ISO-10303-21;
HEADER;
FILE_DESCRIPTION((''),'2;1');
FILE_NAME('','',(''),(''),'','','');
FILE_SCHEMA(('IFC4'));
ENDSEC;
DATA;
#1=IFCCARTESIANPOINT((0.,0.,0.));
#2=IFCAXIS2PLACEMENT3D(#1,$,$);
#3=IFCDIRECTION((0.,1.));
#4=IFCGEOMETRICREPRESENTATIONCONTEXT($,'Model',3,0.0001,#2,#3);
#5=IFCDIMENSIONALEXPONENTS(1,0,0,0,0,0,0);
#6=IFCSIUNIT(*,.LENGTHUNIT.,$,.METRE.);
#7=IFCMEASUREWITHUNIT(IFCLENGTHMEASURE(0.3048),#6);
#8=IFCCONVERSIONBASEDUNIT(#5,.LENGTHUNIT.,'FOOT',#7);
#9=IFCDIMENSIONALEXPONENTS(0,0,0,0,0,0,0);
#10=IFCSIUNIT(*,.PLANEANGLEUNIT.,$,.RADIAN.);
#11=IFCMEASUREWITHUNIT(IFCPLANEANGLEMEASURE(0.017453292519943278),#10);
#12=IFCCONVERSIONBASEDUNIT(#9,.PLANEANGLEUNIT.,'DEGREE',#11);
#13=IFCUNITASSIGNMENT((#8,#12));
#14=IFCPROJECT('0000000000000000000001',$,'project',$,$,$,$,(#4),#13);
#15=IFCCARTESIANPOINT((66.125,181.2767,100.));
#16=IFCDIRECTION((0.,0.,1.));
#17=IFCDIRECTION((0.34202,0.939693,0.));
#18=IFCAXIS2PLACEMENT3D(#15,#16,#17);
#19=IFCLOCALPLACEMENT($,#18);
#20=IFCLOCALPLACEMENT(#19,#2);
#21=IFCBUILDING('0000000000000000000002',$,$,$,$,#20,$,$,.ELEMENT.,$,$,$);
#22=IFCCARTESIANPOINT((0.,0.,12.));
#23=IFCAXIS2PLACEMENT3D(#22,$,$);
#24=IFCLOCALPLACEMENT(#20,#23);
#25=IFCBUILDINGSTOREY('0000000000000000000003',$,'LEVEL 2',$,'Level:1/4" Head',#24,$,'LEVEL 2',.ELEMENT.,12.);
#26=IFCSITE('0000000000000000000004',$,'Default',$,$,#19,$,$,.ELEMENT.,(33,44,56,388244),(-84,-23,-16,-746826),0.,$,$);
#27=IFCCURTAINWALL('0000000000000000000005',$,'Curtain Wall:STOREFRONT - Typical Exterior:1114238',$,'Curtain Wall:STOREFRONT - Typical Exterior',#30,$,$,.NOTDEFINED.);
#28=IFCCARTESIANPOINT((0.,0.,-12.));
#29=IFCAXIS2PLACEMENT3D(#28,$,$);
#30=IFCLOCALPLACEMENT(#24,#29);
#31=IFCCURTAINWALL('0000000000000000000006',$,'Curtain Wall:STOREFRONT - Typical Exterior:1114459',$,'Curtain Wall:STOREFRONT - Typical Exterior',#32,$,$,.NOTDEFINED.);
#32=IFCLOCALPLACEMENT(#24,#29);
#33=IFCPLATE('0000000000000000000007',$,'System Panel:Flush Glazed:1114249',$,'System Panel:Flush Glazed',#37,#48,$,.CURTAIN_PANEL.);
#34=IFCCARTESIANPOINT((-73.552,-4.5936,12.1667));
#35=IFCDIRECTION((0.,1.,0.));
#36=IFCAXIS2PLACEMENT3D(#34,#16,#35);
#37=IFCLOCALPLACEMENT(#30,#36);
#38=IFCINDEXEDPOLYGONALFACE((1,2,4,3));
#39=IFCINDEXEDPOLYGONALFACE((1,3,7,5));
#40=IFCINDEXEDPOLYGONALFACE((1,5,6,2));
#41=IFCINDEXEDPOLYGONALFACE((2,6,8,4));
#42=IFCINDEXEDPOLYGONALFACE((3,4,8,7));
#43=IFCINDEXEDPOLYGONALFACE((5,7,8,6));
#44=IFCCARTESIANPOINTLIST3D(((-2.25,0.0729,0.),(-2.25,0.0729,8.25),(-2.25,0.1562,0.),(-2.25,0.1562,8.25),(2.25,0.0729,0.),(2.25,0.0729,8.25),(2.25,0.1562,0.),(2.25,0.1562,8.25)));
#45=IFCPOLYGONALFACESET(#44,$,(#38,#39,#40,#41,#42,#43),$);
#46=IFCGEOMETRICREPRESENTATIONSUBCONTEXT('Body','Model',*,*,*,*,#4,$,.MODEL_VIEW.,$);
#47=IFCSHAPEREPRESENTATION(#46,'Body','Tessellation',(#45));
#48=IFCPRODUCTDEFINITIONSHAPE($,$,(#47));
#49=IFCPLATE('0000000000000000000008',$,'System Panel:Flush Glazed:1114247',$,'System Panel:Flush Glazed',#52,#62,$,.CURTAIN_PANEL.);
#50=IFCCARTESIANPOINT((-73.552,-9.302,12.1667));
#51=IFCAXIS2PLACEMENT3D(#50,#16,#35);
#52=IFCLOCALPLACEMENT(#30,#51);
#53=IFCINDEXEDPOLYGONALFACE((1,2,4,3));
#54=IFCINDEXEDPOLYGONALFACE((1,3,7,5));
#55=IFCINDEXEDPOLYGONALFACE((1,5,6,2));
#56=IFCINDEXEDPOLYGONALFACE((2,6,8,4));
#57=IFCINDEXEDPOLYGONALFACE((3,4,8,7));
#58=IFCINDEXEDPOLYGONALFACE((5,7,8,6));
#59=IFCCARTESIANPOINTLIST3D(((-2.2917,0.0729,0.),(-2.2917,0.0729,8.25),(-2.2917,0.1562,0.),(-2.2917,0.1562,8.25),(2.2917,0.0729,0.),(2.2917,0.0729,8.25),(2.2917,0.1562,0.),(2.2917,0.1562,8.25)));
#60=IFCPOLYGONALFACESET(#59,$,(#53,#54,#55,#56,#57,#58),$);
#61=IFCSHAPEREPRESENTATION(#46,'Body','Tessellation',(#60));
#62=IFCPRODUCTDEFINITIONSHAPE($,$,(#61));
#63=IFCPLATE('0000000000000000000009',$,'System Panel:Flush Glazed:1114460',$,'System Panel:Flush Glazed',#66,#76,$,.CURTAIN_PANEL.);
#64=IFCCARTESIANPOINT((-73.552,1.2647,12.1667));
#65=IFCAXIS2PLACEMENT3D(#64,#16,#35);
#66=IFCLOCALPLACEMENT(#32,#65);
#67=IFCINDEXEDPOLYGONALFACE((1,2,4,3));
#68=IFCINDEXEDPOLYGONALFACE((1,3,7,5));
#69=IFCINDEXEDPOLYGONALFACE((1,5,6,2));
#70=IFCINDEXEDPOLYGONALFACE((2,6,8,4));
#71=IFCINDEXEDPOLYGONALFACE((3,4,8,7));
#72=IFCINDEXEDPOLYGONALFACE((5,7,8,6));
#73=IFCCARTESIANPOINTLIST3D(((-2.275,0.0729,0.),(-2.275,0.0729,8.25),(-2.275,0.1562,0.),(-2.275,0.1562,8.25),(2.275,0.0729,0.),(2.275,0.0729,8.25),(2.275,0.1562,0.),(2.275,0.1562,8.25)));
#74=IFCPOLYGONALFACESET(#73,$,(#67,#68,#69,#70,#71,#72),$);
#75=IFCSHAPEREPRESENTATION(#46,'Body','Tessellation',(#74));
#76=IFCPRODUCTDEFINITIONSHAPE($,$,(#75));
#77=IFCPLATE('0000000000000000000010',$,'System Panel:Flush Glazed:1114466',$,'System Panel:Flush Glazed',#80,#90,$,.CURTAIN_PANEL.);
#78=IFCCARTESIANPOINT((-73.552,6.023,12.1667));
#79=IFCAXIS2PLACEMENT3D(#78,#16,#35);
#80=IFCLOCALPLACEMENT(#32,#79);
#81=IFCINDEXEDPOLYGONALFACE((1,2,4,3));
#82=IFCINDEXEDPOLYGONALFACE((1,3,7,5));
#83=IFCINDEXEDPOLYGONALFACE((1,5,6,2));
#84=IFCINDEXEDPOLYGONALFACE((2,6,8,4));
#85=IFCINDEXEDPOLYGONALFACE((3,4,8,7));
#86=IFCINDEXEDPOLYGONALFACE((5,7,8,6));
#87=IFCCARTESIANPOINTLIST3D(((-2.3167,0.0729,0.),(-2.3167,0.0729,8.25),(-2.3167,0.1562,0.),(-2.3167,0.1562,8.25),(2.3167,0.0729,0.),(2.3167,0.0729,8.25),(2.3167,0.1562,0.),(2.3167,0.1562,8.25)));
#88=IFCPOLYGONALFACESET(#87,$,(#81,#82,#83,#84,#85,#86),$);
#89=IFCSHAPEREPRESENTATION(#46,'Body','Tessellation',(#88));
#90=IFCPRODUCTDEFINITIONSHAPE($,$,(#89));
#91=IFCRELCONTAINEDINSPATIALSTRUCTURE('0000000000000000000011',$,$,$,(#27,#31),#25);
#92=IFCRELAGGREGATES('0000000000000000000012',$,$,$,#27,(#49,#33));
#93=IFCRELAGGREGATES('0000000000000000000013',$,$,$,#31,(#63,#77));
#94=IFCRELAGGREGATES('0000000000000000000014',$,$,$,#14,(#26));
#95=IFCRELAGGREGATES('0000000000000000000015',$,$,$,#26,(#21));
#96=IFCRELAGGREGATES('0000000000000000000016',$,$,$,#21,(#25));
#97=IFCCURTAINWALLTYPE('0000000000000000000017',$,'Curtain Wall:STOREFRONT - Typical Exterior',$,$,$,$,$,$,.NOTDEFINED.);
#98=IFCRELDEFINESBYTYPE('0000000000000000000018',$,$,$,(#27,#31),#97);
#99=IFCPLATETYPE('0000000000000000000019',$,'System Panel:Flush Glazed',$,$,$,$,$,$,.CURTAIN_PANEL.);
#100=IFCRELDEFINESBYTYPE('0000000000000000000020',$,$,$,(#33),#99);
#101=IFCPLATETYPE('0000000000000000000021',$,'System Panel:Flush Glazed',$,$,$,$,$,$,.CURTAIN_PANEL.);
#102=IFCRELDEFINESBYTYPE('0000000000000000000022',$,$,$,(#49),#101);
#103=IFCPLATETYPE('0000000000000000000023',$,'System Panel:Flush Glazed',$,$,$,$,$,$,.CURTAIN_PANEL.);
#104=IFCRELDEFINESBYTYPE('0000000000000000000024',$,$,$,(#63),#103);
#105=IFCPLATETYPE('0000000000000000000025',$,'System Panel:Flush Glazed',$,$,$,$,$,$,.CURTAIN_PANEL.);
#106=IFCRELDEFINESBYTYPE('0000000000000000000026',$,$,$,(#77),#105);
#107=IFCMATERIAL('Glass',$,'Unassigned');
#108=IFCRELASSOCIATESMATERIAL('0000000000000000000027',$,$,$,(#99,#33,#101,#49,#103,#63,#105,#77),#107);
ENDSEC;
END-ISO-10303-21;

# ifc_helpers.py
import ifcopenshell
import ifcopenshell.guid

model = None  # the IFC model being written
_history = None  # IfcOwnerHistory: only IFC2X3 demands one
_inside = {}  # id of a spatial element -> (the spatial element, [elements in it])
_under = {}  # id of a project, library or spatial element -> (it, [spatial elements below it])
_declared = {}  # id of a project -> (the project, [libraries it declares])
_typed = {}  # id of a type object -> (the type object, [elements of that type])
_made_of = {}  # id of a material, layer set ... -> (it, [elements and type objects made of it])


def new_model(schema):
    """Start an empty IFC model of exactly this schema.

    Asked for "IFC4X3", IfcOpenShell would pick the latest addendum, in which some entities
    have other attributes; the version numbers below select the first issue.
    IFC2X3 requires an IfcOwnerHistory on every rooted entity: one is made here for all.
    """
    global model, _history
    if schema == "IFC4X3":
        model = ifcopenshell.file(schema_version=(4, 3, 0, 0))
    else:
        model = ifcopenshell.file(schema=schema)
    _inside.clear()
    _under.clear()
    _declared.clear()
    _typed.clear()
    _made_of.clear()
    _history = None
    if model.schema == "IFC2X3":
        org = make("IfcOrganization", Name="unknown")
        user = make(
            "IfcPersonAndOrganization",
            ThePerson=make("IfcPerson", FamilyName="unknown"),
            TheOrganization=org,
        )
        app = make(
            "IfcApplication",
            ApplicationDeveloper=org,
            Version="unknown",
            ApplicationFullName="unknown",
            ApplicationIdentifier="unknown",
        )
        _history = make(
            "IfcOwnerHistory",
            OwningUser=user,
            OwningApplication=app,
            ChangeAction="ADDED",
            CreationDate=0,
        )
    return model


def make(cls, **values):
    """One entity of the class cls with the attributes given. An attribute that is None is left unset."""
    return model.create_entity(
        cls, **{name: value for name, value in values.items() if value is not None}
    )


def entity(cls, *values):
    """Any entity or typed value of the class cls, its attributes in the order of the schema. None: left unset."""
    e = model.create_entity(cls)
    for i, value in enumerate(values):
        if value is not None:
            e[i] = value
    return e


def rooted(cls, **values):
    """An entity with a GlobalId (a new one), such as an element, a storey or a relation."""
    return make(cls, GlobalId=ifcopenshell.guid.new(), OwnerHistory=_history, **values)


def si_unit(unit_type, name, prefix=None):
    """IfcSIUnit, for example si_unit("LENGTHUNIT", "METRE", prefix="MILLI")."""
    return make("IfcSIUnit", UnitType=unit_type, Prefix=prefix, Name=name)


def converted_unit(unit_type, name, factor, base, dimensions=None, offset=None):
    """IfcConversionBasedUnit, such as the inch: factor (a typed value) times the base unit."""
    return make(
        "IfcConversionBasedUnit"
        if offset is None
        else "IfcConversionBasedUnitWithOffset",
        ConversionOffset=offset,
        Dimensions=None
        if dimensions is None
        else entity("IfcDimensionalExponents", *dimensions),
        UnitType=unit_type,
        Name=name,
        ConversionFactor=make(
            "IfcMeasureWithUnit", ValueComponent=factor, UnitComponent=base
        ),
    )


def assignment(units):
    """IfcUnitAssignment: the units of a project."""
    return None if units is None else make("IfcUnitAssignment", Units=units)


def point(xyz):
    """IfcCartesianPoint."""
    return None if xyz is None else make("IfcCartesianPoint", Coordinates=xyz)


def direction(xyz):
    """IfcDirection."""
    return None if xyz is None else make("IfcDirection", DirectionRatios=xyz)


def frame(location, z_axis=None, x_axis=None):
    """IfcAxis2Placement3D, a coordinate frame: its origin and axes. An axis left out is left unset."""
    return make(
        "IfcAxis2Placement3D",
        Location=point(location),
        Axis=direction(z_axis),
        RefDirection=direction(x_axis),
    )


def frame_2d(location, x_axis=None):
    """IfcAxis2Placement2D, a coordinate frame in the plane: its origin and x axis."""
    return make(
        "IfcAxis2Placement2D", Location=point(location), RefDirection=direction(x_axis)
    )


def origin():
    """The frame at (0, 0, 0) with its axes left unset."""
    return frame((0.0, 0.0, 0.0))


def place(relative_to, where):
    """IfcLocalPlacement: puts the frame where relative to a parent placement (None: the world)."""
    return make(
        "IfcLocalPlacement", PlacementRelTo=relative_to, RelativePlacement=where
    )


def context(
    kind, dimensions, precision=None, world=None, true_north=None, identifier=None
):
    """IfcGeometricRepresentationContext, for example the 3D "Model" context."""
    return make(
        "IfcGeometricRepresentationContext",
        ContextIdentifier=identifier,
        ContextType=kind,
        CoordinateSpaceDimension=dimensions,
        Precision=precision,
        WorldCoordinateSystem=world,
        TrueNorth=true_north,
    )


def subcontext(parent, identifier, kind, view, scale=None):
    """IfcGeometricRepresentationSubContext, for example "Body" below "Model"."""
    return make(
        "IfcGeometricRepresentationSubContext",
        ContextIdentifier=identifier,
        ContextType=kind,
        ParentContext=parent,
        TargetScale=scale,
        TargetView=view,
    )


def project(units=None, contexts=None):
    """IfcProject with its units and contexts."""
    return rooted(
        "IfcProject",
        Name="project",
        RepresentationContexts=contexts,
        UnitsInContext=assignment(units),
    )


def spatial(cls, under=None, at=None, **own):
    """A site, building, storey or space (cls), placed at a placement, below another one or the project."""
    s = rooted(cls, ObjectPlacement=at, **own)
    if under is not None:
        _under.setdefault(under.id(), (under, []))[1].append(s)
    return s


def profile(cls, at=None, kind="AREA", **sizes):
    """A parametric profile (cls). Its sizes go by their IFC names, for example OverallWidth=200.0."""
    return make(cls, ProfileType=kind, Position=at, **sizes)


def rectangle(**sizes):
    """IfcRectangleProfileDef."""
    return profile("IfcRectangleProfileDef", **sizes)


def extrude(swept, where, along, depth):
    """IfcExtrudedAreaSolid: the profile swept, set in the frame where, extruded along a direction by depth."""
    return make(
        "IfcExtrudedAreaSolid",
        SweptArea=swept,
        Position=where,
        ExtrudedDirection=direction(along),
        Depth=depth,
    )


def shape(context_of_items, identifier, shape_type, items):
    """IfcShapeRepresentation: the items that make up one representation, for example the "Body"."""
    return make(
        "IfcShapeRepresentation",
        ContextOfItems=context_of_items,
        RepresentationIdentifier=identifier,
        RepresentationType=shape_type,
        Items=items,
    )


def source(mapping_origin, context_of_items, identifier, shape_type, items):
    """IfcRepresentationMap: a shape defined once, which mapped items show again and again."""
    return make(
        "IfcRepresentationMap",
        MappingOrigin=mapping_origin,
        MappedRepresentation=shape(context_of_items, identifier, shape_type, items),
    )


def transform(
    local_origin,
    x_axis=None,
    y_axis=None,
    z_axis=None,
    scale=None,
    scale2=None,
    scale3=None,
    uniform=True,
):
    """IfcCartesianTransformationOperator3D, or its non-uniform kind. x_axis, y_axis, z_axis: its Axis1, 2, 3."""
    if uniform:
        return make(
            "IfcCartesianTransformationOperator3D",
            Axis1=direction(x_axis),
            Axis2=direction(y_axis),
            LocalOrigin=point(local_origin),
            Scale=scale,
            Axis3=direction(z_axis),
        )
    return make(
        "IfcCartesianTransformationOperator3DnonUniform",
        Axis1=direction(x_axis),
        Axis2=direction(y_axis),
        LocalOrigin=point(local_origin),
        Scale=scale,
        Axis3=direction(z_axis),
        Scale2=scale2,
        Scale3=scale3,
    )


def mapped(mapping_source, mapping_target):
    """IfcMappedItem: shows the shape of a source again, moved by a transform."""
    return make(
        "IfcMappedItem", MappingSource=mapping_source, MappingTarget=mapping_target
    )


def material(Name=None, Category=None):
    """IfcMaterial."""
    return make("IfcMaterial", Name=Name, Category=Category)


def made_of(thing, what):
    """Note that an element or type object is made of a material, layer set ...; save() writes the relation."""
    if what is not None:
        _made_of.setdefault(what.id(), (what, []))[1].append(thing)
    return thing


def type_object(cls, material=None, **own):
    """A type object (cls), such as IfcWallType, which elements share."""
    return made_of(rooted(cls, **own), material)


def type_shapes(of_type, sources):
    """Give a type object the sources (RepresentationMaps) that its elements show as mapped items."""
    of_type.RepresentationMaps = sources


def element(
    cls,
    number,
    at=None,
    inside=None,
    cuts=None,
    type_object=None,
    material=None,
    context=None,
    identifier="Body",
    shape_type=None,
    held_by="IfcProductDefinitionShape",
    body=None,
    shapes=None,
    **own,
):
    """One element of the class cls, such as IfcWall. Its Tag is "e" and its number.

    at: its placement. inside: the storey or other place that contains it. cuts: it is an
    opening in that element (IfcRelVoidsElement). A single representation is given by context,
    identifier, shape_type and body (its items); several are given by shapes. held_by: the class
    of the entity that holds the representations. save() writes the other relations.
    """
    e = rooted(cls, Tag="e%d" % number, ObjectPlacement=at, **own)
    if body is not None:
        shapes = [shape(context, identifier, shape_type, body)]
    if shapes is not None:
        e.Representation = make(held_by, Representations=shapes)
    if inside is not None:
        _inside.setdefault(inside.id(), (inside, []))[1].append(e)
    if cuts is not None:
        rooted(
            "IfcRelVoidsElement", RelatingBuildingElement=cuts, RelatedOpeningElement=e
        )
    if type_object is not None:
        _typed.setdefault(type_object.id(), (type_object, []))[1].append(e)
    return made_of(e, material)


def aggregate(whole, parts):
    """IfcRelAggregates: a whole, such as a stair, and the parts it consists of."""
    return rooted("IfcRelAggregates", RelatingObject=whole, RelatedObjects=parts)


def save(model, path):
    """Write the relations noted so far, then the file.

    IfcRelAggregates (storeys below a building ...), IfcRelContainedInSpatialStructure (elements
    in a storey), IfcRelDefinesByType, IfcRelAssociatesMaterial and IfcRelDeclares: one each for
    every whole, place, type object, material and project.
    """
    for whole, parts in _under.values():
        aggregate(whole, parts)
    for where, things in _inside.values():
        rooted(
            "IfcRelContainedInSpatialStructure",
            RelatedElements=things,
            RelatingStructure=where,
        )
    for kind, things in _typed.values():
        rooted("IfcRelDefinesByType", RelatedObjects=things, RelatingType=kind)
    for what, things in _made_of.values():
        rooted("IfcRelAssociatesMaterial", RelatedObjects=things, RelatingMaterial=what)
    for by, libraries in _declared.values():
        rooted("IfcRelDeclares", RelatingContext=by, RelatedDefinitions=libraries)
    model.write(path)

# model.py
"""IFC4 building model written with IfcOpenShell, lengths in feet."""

from ifc_helpers import new_model, entity, si_unit, converted_unit, direction, frame, frame_2d, origin, place, context, subcontext, project, spatial, rectangle, extrude, source, transform, mapped, material, type_object, type_shapes, element, aggregate, save


model = new_model("IFC4")

# Units and contexts
model_context = context("Model", 3, precision=0.0001, world=origin(), true_north=direction((0.0, 1.0)))
body_context = subcontext(model_context, "Body", "Model", "MODEL_VIEW")
ifc_project = project(units=[converted_unit("LENGTHUNIT", "FOOT", entity("IfcLengthMeasure", 0.3048), si_unit("LENGTHUNIT", "METRE"), dimensions=[1, 0, 0, 0, 0, 0, 0]), converted_unit("PLANEANGLEUNIT", "DEGREE", entity("IfcPlaneAngleMeasure", 0.017453292519943278), si_unit("PLANEANGLEUNIT", "RADIAN"), dimensions=[0, 0, 0, 0, 0, 0, 0])], contexts=[model_context])

# Site, building, storey
site_placement = place(None, frame((66.125, 181.2767, 100.0), z_axis=(0.0, 0.0, 1.0), x_axis=(0.34202, 0.939693, 0.0)))
site = spatial("IfcSite", under=ifc_project, at=site_placement, Name="Default", CompositionType="ELEMENT", RefLatitude=(33, 44, 56, 388244), RefLongitude=(-84, -23, -16, -746826), RefElevation=0.0)
building_placement = place(site_placement, origin())
building = spatial("IfcBuilding", under=site, at=building_placement, CompositionType="ELEMENT")
storey_placement = place(building_placement, frame((0.0, 0.0, 12.0)))
storey = spatial("IfcBuildingStorey", under=building, at=storey_placement, Name="LEVEL 2", ObjectType="Level:1/4\" Head", LongName="LEVEL 2", CompositionType="ELEMENT", Elevation=12.0)

# Curtain walls
curtain_wall_type = type_object("IfcCurtainWallType", Name="Curtain Wall:STOREFRONT - Typical Exterior", PredefinedType="NOTDEFINED")
curtain_wall_1_placement = place(storey_placement, frame((0.0, 0.0, -12.0)))
curtain_wall_1 = element("IfcCurtainWall", 1, at=curtain_wall_1_placement, inside=storey, type_object=curtain_wall_type, Name="Curtain Wall:STOREFRONT - Typical Exterior:1114238", ObjectType="Curtain Wall:STOREFRONT - Typical Exterior", PredefinedType="NOTDEFINED")
curtain_wall_2_placement = place(storey_placement, frame((0.0, 0.0, -12.0)))
curtain_wall_2 = element("IfcCurtainWall", 2, at=curtain_wall_2_placement, inside=storey, type_object=curtain_wall_type, Name="Curtain Wall:STOREFRONT - Typical Exterior:1114459", ObjectType="Curtain Wall:STOREFRONT - Typical Exterior", PredefinedType="NOTDEFINED")

# Plates
ifc_material_1 = material(Name="Glass", Category="Unassigned")
plate_type_1 = type_object("IfcPlateType", Name="System Panel:Flush Glazed", PredefinedType="CURTAIN_PANEL", material=ifc_material_1)
shared_shape_1 = source(origin(), body_context, "Body", "SweptSolid", [
    extrude(rectangle(XDim=0.0833, YDim=4.5, at=frame_2d((0.0, 0.0), x_axis=(1.0, 0.0))), frame((0.0, 0.1146, 0.0), z_axis=(0.0, 0.0, 1.0), x_axis=(0.0, 1.0, 0.0)), (0.0, 0.0, 1.0), 8.25),
])
type_shapes(plate_type_1, [shared_shape_1])
plate_1_placement = place(curtain_wall_1_placement, frame((-73.552, -4.5936, 12.1667), z_axis=(0.0, 0.0, 1.0), x_axis=(0.0, 1.0, 0.0)))
plate_1 = element("IfcPlate", 3, at=plate_1_placement, type_object=plate_type_1, material=ifc_material_1, Name="System Panel:Flush Glazed:1114249", ObjectType="System Panel:Flush Glazed", PredefinedType="CURTAIN_PANEL", context=body_context, shape_type="MappedRepresentation", body=[
    mapped(shared_shape_1, transform((0.0, 0.0, 0.0), scale=1.0)),
])
plate_type_2 = type_object("IfcPlateType", Name="System Panel:Flush Glazed", PredefinedType="CURTAIN_PANEL", material=ifc_material_1)
shared_shape_2 = source(origin(), body_context, "Body", "SweptSolid", [
    extrude(rectangle(XDim=0.0833, YDim=4.5833, at=frame_2d((0.0, 0.0), x_axis=(1.0, 0.0))), frame((0.0, 0.1146, 0.0), z_axis=(0.0, 0.0, 1.0), x_axis=(0.0, 1.0, 0.0)), (0.0, 0.0, 1.0), 8.25),
])
type_shapes(plate_type_2, [shared_shape_2])
plate_2_placement = place(curtain_wall_1_placement, frame((-73.552, -9.302, 12.1667), z_axis=(0.0, 0.0, 1.0), x_axis=(0.0, 1.0, 0.0)))
plate_2 = element("IfcPlate", 4, at=plate_2_placement, type_object=plate_type_2, material=ifc_material_1, Name="System Panel:Flush Glazed:1114247", ObjectType="System Panel:Flush Glazed", PredefinedType="CURTAIN_PANEL", context=body_context, shape_type="MappedRepresentation", body=[
    mapped(shared_shape_2, transform((0.0, 0.0, 0.0), scale=1.0)),
])
aggregate(curtain_wall_1, [plate_2, plate_1])
plate_type_3 = type_object("IfcPlateType", Name="System Panel:Flush Glazed", PredefinedType="CURTAIN_PANEL", material=ifc_material_1)
shared_shape_3 = source(origin(), body_context, "Body", "SweptSolid", [
    extrude(rectangle(XDim=0.0833, YDim=4.55, at=frame_2d((0.0, 0.0), x_axis=(1.0, 0.0))), frame((0.0, 0.1146, 0.0), z_axis=(0.0, 0.0, 1.0), x_axis=(0.0, 1.0, 0.0)), (0.0, 0.0, 1.0), 8.25),
])
type_shapes(plate_type_3, [shared_shape_3])
plate_3_placement = place(curtain_wall_2_placement, frame((-73.552, 1.2647, 12.1667), z_axis=(0.0, 0.0, 1.0), x_axis=(0.0, 1.0, 0.0)))
plate_3 = element("IfcPlate", 5, at=plate_3_placement, type_object=plate_type_3, material=ifc_material_1, Name="System Panel:Flush Glazed:1114460", ObjectType="System Panel:Flush Glazed", PredefinedType="CURTAIN_PANEL", context=body_context, shape_type="MappedRepresentation", body=[
    mapped(shared_shape_3, transform((0.0, 0.0, 0.0), scale=1.0)),
])
plate_type_4 = type_object("IfcPlateType", Name="System Panel:Flush Glazed", PredefinedType="CURTAIN_PANEL", material=ifc_material_1)
shared_shape_4 = source(origin(), body_context, "Body", "SweptSolid", [
    extrude(rectangle(XDim=0.0833, YDim=4.6333, at=frame_2d((0.0, 0.0), x_axis=(1.0, 0.0))), frame((0.0, 0.1146, 0.0), z_axis=(0.0, 0.0, 1.0), x_axis=(0.0, 1.0, 0.0)), (0.0, 0.0, 1.0), 8.25),
])
type_shapes(plate_type_4, [shared_shape_4])
plate_4_placement = place(curtain_wall_2_placement, frame((-73.552, 6.023, 12.1667), z_axis=(0.0, 0.0, 1.0), x_axis=(0.0, 1.0, 0.0)))
plate_4 = element("IfcPlate", 6, at=plate_4_placement, type_object=plate_type_4, material=ifc_material_1, Name="System Panel:Flush Glazed:1114466", ObjectType="System Panel:Flush Glazed", PredefinedType="CURTAIN_PANEL", context=body_context, shape_type="MappedRepresentation", body=[
    mapped(shared_shape_4, transform((0.0, 0.0, 0.0), scale=1.0)),
])
aggregate(curtain_wall_2, [plate_3, plate_4])

save(model, "model.ifc")
